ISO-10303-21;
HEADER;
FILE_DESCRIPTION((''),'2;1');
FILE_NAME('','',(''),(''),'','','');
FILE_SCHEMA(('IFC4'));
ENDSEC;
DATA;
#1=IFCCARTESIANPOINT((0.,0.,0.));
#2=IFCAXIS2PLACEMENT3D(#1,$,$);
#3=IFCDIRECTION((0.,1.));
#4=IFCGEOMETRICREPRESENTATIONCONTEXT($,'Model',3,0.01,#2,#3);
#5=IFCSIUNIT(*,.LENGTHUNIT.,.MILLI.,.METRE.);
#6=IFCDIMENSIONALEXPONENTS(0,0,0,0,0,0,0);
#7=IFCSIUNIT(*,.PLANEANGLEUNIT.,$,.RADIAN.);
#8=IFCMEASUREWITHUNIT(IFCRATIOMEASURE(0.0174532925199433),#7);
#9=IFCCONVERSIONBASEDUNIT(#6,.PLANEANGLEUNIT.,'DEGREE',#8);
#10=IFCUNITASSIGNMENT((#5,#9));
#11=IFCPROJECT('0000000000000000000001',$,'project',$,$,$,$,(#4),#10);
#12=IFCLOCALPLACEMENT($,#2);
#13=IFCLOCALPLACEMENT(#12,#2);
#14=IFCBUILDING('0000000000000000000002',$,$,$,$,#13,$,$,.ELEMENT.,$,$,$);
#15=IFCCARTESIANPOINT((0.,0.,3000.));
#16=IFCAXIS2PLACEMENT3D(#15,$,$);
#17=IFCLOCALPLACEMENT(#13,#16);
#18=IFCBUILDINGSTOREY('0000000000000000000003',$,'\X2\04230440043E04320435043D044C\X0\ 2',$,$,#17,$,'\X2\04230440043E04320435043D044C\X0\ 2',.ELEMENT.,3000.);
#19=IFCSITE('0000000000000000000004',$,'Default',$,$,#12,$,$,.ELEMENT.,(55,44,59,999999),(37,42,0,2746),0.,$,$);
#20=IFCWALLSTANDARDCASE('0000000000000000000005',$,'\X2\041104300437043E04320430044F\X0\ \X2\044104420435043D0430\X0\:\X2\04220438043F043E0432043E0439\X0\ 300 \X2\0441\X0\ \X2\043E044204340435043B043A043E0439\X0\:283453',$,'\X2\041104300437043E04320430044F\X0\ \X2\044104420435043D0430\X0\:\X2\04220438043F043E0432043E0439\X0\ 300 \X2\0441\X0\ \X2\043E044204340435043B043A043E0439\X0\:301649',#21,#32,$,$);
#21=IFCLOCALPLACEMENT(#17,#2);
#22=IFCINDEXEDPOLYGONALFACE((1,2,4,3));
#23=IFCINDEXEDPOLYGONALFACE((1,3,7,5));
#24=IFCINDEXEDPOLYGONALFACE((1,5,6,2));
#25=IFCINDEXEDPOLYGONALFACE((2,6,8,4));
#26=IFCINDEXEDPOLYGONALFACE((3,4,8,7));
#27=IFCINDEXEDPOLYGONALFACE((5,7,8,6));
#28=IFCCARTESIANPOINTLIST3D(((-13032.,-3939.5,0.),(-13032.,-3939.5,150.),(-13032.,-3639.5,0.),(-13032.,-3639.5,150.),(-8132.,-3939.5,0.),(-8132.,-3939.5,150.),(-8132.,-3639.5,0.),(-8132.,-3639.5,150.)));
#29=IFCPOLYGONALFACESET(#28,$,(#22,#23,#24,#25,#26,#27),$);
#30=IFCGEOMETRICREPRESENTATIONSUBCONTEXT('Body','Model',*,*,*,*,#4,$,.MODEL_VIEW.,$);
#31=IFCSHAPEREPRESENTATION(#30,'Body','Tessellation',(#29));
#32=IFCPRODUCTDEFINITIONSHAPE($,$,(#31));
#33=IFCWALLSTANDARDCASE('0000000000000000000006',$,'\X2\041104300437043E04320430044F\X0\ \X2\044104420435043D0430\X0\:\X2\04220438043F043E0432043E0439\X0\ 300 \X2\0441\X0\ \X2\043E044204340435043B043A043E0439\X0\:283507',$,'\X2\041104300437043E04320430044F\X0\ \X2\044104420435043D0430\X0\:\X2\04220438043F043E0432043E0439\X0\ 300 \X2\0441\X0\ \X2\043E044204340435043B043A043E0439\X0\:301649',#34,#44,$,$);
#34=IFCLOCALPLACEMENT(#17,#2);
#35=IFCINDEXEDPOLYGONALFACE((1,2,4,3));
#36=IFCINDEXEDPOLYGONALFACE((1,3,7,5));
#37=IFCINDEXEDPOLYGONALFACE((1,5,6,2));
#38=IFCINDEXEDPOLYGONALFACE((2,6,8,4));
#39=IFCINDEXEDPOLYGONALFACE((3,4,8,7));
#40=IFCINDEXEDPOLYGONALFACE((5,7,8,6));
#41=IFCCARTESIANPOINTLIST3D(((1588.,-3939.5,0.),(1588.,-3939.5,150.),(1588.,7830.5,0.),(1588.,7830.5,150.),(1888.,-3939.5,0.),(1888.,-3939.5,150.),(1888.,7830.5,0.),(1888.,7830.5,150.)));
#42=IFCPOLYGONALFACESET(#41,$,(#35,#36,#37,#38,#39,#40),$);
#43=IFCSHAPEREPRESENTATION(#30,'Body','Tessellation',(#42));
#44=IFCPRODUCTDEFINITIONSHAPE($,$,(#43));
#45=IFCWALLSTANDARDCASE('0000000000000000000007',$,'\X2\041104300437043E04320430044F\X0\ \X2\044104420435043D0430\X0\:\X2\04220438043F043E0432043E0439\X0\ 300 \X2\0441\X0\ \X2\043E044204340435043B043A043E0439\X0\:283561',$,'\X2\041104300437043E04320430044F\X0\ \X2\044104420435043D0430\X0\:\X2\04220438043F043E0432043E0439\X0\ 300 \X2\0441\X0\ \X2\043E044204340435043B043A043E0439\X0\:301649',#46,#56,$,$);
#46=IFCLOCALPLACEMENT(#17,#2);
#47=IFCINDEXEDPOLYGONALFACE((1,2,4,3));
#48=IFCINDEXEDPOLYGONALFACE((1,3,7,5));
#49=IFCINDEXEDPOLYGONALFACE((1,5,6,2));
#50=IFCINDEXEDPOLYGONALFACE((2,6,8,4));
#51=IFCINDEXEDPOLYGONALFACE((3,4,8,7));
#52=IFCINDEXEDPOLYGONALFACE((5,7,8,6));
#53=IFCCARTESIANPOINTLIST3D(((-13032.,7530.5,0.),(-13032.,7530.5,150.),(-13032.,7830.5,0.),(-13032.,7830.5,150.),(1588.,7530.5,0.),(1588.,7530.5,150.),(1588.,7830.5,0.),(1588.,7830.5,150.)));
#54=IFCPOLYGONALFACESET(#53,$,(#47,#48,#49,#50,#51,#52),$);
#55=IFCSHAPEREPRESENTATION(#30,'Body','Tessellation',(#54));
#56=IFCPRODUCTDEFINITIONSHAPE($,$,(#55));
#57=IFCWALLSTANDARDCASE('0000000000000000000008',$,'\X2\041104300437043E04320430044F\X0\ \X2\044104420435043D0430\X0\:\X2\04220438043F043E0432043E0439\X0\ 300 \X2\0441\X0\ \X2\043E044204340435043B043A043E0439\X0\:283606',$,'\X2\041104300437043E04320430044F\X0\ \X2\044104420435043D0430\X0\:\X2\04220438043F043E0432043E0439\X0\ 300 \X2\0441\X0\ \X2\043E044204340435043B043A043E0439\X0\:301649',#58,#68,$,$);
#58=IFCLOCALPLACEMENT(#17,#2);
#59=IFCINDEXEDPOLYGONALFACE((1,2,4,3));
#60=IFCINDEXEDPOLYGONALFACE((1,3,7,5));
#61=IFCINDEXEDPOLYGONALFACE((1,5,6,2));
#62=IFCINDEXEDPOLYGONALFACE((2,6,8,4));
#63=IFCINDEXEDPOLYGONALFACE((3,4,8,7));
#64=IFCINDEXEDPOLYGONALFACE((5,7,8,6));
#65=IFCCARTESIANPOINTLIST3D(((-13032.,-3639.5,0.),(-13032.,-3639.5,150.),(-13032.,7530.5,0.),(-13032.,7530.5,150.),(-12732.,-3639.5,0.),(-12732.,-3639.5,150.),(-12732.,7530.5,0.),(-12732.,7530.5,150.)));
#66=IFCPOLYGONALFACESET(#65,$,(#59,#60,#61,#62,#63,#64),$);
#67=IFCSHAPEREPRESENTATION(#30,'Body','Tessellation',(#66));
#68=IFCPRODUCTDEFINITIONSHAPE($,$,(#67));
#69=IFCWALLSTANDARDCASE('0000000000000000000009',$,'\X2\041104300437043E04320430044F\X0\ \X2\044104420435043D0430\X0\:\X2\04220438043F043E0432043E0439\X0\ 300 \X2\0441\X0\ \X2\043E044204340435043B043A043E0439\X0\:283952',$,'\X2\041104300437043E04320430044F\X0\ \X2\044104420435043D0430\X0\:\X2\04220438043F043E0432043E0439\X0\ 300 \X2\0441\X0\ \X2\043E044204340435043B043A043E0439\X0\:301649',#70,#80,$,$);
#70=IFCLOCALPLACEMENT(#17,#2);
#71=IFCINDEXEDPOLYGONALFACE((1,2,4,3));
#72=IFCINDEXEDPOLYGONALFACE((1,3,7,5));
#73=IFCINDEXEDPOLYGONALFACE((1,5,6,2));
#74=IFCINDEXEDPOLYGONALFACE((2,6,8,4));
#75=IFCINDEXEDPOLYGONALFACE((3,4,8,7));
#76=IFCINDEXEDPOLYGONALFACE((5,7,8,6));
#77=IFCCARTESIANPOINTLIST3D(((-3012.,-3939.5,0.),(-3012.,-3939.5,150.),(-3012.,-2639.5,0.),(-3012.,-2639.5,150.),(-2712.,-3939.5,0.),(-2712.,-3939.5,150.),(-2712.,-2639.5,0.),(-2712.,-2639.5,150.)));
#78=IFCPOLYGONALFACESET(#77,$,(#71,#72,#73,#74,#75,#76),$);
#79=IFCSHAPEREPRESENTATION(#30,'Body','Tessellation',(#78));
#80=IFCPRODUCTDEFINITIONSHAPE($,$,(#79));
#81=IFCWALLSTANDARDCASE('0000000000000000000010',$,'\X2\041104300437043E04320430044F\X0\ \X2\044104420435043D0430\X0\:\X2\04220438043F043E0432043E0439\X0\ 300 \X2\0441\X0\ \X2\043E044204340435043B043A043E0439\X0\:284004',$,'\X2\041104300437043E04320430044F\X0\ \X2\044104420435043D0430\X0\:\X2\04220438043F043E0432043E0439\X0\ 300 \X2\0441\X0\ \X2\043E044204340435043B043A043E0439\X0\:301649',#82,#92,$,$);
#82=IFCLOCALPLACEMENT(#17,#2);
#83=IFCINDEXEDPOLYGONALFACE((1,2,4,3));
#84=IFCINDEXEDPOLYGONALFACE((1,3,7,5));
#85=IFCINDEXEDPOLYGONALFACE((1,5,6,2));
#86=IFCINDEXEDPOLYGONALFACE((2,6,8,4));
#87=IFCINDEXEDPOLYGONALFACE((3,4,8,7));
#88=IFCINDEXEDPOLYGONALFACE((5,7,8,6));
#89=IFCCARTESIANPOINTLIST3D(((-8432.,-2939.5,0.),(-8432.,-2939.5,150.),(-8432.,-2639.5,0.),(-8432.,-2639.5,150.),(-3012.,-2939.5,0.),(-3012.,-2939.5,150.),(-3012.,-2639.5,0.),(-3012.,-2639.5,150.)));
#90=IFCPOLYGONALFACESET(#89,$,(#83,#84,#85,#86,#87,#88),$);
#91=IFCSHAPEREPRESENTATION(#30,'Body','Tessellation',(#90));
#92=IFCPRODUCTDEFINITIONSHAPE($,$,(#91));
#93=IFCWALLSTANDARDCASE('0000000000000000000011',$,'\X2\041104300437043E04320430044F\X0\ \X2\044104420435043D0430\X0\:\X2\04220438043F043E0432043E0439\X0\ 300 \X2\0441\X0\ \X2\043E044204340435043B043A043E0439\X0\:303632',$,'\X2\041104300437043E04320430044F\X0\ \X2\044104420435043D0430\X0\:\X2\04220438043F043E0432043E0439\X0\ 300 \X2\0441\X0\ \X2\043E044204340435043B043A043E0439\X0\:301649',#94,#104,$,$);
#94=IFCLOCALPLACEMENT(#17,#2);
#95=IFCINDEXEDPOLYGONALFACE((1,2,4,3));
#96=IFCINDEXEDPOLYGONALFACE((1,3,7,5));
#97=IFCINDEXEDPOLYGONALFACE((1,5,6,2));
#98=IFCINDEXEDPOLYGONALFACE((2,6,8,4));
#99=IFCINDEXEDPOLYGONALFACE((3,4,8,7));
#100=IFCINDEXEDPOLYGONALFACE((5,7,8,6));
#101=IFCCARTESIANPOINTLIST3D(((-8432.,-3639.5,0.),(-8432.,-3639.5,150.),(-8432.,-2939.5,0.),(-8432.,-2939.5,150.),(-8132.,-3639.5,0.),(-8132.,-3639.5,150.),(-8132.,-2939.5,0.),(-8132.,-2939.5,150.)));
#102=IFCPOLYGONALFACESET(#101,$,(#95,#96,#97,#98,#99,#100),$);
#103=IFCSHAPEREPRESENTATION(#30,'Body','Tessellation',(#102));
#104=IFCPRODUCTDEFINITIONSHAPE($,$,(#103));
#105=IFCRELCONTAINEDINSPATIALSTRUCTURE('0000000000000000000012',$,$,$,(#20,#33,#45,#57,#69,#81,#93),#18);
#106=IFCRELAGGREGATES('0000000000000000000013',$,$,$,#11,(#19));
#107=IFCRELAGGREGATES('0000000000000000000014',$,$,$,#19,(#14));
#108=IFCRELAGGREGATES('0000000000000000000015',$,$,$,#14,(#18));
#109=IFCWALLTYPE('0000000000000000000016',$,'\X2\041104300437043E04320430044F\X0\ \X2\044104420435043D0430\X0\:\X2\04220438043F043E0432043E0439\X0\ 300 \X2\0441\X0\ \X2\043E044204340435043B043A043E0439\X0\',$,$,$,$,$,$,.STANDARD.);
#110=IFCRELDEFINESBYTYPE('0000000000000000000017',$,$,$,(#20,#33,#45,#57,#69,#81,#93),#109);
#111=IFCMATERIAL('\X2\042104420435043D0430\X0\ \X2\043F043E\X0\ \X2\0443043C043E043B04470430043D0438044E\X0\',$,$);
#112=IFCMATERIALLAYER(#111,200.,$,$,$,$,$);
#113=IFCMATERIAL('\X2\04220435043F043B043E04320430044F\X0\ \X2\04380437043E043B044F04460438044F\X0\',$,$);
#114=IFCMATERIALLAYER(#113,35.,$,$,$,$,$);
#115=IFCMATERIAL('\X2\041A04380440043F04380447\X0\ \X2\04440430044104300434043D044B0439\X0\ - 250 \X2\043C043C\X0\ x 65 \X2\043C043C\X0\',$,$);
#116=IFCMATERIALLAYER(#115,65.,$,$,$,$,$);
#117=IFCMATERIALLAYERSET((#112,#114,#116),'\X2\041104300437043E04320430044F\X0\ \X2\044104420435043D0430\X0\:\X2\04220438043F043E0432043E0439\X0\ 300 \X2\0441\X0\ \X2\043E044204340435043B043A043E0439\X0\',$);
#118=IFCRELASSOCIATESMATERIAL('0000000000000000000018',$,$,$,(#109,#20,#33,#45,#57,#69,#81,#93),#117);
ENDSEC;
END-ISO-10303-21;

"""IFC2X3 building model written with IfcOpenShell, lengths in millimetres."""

from ifc_helpers import new_model, entity, si_unit, converted_unit, direction, frame, frame_2d, origin, place, context, subcontext, project, spatial, rectangle, extrude, clip, halfspace, material, layer, layer_set, layer_usage, type_object, element, save


model = new_model("IFC2X3")

# Units and contexts
model_context = context("Model", 3, precision=0.01, world=origin(), true_north=direction((0.0, 1.0)))
body_context = subcontext(model_context, "Body", "Model", "MODEL_VIEW")
ifc_project = project(units=[si_unit("LENGTHUNIT", "METRE", prefix="MILLI"), converted_unit("PLANEANGLEUNIT", "DEGREE", entity("IfcRatioMeasure", 0.0174532925199433), si_unit("PLANEANGLEUNIT", "RADIAN"), dimensions=[0, 0, 0, 0, 0, 0, 0])], contexts=[model_context])

# Site, building, storey
site_placement = place(None, origin())
site = spatial("IfcSite", under=ifc_project, at=site_placement, Name="Default", CompositionType="ELEMENT", RefLatitude=(55, 44, 59, 999999), RefLongitude=(37, 42, 0, 2746), RefElevation=0.0)
building_placement = place(site_placement, origin())
building = spatial("IfcBuilding", under=site, at=building_placement, CompositionType="ELEMENT")
storey_placement = place(building_placement, frame((0.0, 0.0, 3000.0)))
storey = spatial("IfcBuildingStorey", under=building, at=storey_placement, Name="Уровень 2", LongName="Уровень 2", CompositionType="ELEMENT", Elevation=3000.0)

# Walls
ifc_material_1 = material(Name="Стена по умолчанию")
ifc_layer_1 = layer(ifc_material_1, 200.0)
ifc_material_2 = material(Name="Тепловая изоляция")
ifc_layer_2 = layer(ifc_material_2, 35.0)
ifc_material_3 = material(Name="Кирпич фасадный - 250 мм x 65 мм")
ifc_layer_3 = layer(ifc_material_3, 65.0)
ifc_layer_set_1 = layer_set([ifc_layer_1, ifc_layer_2, ifc_layer_3], Name="Базовая стена:Типовой 300 с отделкой")
ifc_layer_usage_1 = layer_usage(ifc_layer_set_1, "AXIS2", "NEGATIVE", 150.0)
wall_type = type_object("IfcWallType", Name="Базовая стена:Типовой 300 с отделкой", PredefinedType="STANDARD", material=ifc_layer_set_1)
wall_1_placement = place(storey_placement, frame((-13032.0, -3789.5, 0.0)))
element("IfcWallStandardCase", 1, at=wall_1_placement, inside=storey, type_object=wall_type, material=ifc_layer_usage_1, Name="Базовая стена:Типовой 300 с отделкой:283453", ObjectType="Базовая стена:Типовой 300 с отделкой:301649", context=body_context, shape_type="Clipping", body=[
    clip(extrude(rectangle(XDim=4900.0, YDim=300.0, at=frame_2d((2450.0, 0.0), x_axis=(-1.0, 0.0))), origin(), (0.0, 0.0, 1.0), 150.0), halfspace(frame((0.0, 0.0, -3000.0)), True)),
])
ifc_layer_usage_2 = layer_usage(ifc_layer_set_1, "AXIS2", "NEGATIVE", 150.0)
wall_2_placement = place(storey_placement, frame((1738.0, -3939.5, 0.0), z_axis=(0.0, 0.0, 1.0), x_axis=(0.0, 1.0, 0.0)))
element("IfcWallStandardCase", 2, at=wall_2_placement, inside=storey, type_object=wall_type, material=ifc_layer_usage_2, Name="Базовая стена:Типовой 300 с отделкой:283507", ObjectType="Базовая стена:Типовой 300 с отделкой:301649", context=body_context, shape_type="Clipping", body=[
    clip(extrude(rectangle(XDim=11770.0, YDim=300.0, at=frame_2d((5885.0, 0.0), x_axis=(-1.0, 0.0))), origin(), (0.0, 0.0, 1.0), 150.0), halfspace(frame((0.0, 0.0, -3000.0)), True)),
])
ifc_layer_usage_3 = layer_usage(ifc_layer_set_1, "AXIS2", "NEGATIVE", 150.0)
wall_3_placement = place(storey_placement, frame((1588.0, 7680.5, 0.0), z_axis=(0.0, 0.0, 1.0), x_axis=(-1.0, 0.0, 0.0)))
element("IfcWallStandardCase", 3, at=wall_3_placement, inside=storey, type_object=wall_type, material=ifc_layer_usage_3, Name="Базовая стена:Типовой 300 с отделкой:283561", ObjectType="Базовая стена:Типовой 300 с отделкой:301649", context=body_context, shape_type="Clipping", body=[
    clip(extrude(rectangle(XDim=14620.0, YDim=300.0, at=frame_2d((7310.0, 0.0), x_axis=(-1.0, 0.0))), origin(), (0.0, 0.0, 1.0), 150.0), halfspace(frame((0.0, 0.0, -3000.0)), True)),
])
ifc_layer_usage_4 = layer_usage(ifc_layer_set_1, "AXIS2", "NEGATIVE", 150.0)
wall_4_placement = place(storey_placement, frame((-12882.0, 7530.5, 0.0), z_axis=(0.0, 0.0, 1.0), x_axis=(0.0, -1.0, 0.0)))
element("IfcWallStandardCase", 4, at=wall_4_placement, inside=storey, type_object=wall_type, material=ifc_layer_usage_4, Name="Базовая стена:Типовой 300 с отделкой:283606", ObjectType="Базовая стена:Типовой 300 с отделкой:301649", context=body_context, shape_type="Clipping", body=[
    clip(extrude(rectangle(XDim=11170.0, YDim=300.0, at=frame_2d((5585.0, 0.0), x_axis=(-1.0, 0.0))), origin(), (0.0, 0.0, 1.0), 150.0), halfspace(frame((0.0, 0.0, -3000.0)), True)),
])
ifc_layer_usage_5 = layer_usage(ifc_layer_set_1, "AXIS2", "NEGATIVE", 150.0)
wall_5_placement = place(storey_placement, frame((-2862.0, -2639.5, 0.0), z_axis=(0.0, 0.0, 1.0), x_axis=(0.0, -1.0, 0.0)))
element("IfcWallStandardCase", 5, at=wall_5_placement, inside=storey, type_object=wall_type, material=ifc_layer_usage_5, Name="Базовая стена:Типовой 300 с отделкой:283952", ObjectType="Базовая стена:Типовой 300 с отделкой:301649", context=body_context, shape_type="Clipping", body=[
    clip(extrude(rectangle(XDim=1300.0, YDim=300.0, at=frame_2d((650.0, 0.0), x_axis=(-1.0, 0.0))), origin(), (0.0, 0.0, 1.0), 150.0), halfspace(frame((0.0, 0.0, -3000.0)), True)),
])
ifc_layer_usage_6 = layer_usage(ifc_layer_set_1, "AXIS2", "NEGATIVE", 150.0)
wall_6_placement = place(storey_placement, frame((-8432.0, -2789.5, 0.0)))
element("IfcWallStandardCase", 6, at=wall_6_placement, inside=storey, type_object=wall_type, material=ifc_layer_usage_6, Name="Базовая стена:Типовой 300 с отделкой:284004", ObjectType="Базовая стена:Типовой 300 с отделкой:301649", context=body_context, shape_type="Clipping", body=[
    clip(extrude(rectangle(XDim=5420.0, YDim=300.0, at=frame_2d((2710.0, 0.0), x_axis=(-1.0, 0.0))), origin(), (0.0, 0.0, 1.0), 150.0), halfspace(frame((0.0, 0.0, -3000.0)), True)),
])
ifc_layer_usage_7 = layer_usage(ifc_layer_set_1, "AXIS2", "NEGATIVE", 150.0)
wall_7_placement = place(storey_placement, frame((-8282.0, -3639.5, 0.0), z_axis=(0.0, 0.0, 1.0), x_axis=(0.0, 1.0, 0.0)))
element("IfcWallStandardCase", 7, at=wall_7_placement, inside=storey, type_object=wall_type, material=ifc_layer_usage_7, Name="Базовая стена:Типовой 300 с отделкой:303632", ObjectType="Базовая стена:Типовой 300 с отделкой:301649", context=body_context, shape_type="Clipping", body=[
    clip(extrude(rectangle(XDim=700.0, YDim=300.0, at=frame_2d((350.0, 0.0), x_axis=(-1.0, 0.0))), origin(), (0.0, 0.0, 1.0), 150.0), halfspace(frame((0.0, 0.0, -3000.0)), True)),
])

save(model, "model.ifc")
